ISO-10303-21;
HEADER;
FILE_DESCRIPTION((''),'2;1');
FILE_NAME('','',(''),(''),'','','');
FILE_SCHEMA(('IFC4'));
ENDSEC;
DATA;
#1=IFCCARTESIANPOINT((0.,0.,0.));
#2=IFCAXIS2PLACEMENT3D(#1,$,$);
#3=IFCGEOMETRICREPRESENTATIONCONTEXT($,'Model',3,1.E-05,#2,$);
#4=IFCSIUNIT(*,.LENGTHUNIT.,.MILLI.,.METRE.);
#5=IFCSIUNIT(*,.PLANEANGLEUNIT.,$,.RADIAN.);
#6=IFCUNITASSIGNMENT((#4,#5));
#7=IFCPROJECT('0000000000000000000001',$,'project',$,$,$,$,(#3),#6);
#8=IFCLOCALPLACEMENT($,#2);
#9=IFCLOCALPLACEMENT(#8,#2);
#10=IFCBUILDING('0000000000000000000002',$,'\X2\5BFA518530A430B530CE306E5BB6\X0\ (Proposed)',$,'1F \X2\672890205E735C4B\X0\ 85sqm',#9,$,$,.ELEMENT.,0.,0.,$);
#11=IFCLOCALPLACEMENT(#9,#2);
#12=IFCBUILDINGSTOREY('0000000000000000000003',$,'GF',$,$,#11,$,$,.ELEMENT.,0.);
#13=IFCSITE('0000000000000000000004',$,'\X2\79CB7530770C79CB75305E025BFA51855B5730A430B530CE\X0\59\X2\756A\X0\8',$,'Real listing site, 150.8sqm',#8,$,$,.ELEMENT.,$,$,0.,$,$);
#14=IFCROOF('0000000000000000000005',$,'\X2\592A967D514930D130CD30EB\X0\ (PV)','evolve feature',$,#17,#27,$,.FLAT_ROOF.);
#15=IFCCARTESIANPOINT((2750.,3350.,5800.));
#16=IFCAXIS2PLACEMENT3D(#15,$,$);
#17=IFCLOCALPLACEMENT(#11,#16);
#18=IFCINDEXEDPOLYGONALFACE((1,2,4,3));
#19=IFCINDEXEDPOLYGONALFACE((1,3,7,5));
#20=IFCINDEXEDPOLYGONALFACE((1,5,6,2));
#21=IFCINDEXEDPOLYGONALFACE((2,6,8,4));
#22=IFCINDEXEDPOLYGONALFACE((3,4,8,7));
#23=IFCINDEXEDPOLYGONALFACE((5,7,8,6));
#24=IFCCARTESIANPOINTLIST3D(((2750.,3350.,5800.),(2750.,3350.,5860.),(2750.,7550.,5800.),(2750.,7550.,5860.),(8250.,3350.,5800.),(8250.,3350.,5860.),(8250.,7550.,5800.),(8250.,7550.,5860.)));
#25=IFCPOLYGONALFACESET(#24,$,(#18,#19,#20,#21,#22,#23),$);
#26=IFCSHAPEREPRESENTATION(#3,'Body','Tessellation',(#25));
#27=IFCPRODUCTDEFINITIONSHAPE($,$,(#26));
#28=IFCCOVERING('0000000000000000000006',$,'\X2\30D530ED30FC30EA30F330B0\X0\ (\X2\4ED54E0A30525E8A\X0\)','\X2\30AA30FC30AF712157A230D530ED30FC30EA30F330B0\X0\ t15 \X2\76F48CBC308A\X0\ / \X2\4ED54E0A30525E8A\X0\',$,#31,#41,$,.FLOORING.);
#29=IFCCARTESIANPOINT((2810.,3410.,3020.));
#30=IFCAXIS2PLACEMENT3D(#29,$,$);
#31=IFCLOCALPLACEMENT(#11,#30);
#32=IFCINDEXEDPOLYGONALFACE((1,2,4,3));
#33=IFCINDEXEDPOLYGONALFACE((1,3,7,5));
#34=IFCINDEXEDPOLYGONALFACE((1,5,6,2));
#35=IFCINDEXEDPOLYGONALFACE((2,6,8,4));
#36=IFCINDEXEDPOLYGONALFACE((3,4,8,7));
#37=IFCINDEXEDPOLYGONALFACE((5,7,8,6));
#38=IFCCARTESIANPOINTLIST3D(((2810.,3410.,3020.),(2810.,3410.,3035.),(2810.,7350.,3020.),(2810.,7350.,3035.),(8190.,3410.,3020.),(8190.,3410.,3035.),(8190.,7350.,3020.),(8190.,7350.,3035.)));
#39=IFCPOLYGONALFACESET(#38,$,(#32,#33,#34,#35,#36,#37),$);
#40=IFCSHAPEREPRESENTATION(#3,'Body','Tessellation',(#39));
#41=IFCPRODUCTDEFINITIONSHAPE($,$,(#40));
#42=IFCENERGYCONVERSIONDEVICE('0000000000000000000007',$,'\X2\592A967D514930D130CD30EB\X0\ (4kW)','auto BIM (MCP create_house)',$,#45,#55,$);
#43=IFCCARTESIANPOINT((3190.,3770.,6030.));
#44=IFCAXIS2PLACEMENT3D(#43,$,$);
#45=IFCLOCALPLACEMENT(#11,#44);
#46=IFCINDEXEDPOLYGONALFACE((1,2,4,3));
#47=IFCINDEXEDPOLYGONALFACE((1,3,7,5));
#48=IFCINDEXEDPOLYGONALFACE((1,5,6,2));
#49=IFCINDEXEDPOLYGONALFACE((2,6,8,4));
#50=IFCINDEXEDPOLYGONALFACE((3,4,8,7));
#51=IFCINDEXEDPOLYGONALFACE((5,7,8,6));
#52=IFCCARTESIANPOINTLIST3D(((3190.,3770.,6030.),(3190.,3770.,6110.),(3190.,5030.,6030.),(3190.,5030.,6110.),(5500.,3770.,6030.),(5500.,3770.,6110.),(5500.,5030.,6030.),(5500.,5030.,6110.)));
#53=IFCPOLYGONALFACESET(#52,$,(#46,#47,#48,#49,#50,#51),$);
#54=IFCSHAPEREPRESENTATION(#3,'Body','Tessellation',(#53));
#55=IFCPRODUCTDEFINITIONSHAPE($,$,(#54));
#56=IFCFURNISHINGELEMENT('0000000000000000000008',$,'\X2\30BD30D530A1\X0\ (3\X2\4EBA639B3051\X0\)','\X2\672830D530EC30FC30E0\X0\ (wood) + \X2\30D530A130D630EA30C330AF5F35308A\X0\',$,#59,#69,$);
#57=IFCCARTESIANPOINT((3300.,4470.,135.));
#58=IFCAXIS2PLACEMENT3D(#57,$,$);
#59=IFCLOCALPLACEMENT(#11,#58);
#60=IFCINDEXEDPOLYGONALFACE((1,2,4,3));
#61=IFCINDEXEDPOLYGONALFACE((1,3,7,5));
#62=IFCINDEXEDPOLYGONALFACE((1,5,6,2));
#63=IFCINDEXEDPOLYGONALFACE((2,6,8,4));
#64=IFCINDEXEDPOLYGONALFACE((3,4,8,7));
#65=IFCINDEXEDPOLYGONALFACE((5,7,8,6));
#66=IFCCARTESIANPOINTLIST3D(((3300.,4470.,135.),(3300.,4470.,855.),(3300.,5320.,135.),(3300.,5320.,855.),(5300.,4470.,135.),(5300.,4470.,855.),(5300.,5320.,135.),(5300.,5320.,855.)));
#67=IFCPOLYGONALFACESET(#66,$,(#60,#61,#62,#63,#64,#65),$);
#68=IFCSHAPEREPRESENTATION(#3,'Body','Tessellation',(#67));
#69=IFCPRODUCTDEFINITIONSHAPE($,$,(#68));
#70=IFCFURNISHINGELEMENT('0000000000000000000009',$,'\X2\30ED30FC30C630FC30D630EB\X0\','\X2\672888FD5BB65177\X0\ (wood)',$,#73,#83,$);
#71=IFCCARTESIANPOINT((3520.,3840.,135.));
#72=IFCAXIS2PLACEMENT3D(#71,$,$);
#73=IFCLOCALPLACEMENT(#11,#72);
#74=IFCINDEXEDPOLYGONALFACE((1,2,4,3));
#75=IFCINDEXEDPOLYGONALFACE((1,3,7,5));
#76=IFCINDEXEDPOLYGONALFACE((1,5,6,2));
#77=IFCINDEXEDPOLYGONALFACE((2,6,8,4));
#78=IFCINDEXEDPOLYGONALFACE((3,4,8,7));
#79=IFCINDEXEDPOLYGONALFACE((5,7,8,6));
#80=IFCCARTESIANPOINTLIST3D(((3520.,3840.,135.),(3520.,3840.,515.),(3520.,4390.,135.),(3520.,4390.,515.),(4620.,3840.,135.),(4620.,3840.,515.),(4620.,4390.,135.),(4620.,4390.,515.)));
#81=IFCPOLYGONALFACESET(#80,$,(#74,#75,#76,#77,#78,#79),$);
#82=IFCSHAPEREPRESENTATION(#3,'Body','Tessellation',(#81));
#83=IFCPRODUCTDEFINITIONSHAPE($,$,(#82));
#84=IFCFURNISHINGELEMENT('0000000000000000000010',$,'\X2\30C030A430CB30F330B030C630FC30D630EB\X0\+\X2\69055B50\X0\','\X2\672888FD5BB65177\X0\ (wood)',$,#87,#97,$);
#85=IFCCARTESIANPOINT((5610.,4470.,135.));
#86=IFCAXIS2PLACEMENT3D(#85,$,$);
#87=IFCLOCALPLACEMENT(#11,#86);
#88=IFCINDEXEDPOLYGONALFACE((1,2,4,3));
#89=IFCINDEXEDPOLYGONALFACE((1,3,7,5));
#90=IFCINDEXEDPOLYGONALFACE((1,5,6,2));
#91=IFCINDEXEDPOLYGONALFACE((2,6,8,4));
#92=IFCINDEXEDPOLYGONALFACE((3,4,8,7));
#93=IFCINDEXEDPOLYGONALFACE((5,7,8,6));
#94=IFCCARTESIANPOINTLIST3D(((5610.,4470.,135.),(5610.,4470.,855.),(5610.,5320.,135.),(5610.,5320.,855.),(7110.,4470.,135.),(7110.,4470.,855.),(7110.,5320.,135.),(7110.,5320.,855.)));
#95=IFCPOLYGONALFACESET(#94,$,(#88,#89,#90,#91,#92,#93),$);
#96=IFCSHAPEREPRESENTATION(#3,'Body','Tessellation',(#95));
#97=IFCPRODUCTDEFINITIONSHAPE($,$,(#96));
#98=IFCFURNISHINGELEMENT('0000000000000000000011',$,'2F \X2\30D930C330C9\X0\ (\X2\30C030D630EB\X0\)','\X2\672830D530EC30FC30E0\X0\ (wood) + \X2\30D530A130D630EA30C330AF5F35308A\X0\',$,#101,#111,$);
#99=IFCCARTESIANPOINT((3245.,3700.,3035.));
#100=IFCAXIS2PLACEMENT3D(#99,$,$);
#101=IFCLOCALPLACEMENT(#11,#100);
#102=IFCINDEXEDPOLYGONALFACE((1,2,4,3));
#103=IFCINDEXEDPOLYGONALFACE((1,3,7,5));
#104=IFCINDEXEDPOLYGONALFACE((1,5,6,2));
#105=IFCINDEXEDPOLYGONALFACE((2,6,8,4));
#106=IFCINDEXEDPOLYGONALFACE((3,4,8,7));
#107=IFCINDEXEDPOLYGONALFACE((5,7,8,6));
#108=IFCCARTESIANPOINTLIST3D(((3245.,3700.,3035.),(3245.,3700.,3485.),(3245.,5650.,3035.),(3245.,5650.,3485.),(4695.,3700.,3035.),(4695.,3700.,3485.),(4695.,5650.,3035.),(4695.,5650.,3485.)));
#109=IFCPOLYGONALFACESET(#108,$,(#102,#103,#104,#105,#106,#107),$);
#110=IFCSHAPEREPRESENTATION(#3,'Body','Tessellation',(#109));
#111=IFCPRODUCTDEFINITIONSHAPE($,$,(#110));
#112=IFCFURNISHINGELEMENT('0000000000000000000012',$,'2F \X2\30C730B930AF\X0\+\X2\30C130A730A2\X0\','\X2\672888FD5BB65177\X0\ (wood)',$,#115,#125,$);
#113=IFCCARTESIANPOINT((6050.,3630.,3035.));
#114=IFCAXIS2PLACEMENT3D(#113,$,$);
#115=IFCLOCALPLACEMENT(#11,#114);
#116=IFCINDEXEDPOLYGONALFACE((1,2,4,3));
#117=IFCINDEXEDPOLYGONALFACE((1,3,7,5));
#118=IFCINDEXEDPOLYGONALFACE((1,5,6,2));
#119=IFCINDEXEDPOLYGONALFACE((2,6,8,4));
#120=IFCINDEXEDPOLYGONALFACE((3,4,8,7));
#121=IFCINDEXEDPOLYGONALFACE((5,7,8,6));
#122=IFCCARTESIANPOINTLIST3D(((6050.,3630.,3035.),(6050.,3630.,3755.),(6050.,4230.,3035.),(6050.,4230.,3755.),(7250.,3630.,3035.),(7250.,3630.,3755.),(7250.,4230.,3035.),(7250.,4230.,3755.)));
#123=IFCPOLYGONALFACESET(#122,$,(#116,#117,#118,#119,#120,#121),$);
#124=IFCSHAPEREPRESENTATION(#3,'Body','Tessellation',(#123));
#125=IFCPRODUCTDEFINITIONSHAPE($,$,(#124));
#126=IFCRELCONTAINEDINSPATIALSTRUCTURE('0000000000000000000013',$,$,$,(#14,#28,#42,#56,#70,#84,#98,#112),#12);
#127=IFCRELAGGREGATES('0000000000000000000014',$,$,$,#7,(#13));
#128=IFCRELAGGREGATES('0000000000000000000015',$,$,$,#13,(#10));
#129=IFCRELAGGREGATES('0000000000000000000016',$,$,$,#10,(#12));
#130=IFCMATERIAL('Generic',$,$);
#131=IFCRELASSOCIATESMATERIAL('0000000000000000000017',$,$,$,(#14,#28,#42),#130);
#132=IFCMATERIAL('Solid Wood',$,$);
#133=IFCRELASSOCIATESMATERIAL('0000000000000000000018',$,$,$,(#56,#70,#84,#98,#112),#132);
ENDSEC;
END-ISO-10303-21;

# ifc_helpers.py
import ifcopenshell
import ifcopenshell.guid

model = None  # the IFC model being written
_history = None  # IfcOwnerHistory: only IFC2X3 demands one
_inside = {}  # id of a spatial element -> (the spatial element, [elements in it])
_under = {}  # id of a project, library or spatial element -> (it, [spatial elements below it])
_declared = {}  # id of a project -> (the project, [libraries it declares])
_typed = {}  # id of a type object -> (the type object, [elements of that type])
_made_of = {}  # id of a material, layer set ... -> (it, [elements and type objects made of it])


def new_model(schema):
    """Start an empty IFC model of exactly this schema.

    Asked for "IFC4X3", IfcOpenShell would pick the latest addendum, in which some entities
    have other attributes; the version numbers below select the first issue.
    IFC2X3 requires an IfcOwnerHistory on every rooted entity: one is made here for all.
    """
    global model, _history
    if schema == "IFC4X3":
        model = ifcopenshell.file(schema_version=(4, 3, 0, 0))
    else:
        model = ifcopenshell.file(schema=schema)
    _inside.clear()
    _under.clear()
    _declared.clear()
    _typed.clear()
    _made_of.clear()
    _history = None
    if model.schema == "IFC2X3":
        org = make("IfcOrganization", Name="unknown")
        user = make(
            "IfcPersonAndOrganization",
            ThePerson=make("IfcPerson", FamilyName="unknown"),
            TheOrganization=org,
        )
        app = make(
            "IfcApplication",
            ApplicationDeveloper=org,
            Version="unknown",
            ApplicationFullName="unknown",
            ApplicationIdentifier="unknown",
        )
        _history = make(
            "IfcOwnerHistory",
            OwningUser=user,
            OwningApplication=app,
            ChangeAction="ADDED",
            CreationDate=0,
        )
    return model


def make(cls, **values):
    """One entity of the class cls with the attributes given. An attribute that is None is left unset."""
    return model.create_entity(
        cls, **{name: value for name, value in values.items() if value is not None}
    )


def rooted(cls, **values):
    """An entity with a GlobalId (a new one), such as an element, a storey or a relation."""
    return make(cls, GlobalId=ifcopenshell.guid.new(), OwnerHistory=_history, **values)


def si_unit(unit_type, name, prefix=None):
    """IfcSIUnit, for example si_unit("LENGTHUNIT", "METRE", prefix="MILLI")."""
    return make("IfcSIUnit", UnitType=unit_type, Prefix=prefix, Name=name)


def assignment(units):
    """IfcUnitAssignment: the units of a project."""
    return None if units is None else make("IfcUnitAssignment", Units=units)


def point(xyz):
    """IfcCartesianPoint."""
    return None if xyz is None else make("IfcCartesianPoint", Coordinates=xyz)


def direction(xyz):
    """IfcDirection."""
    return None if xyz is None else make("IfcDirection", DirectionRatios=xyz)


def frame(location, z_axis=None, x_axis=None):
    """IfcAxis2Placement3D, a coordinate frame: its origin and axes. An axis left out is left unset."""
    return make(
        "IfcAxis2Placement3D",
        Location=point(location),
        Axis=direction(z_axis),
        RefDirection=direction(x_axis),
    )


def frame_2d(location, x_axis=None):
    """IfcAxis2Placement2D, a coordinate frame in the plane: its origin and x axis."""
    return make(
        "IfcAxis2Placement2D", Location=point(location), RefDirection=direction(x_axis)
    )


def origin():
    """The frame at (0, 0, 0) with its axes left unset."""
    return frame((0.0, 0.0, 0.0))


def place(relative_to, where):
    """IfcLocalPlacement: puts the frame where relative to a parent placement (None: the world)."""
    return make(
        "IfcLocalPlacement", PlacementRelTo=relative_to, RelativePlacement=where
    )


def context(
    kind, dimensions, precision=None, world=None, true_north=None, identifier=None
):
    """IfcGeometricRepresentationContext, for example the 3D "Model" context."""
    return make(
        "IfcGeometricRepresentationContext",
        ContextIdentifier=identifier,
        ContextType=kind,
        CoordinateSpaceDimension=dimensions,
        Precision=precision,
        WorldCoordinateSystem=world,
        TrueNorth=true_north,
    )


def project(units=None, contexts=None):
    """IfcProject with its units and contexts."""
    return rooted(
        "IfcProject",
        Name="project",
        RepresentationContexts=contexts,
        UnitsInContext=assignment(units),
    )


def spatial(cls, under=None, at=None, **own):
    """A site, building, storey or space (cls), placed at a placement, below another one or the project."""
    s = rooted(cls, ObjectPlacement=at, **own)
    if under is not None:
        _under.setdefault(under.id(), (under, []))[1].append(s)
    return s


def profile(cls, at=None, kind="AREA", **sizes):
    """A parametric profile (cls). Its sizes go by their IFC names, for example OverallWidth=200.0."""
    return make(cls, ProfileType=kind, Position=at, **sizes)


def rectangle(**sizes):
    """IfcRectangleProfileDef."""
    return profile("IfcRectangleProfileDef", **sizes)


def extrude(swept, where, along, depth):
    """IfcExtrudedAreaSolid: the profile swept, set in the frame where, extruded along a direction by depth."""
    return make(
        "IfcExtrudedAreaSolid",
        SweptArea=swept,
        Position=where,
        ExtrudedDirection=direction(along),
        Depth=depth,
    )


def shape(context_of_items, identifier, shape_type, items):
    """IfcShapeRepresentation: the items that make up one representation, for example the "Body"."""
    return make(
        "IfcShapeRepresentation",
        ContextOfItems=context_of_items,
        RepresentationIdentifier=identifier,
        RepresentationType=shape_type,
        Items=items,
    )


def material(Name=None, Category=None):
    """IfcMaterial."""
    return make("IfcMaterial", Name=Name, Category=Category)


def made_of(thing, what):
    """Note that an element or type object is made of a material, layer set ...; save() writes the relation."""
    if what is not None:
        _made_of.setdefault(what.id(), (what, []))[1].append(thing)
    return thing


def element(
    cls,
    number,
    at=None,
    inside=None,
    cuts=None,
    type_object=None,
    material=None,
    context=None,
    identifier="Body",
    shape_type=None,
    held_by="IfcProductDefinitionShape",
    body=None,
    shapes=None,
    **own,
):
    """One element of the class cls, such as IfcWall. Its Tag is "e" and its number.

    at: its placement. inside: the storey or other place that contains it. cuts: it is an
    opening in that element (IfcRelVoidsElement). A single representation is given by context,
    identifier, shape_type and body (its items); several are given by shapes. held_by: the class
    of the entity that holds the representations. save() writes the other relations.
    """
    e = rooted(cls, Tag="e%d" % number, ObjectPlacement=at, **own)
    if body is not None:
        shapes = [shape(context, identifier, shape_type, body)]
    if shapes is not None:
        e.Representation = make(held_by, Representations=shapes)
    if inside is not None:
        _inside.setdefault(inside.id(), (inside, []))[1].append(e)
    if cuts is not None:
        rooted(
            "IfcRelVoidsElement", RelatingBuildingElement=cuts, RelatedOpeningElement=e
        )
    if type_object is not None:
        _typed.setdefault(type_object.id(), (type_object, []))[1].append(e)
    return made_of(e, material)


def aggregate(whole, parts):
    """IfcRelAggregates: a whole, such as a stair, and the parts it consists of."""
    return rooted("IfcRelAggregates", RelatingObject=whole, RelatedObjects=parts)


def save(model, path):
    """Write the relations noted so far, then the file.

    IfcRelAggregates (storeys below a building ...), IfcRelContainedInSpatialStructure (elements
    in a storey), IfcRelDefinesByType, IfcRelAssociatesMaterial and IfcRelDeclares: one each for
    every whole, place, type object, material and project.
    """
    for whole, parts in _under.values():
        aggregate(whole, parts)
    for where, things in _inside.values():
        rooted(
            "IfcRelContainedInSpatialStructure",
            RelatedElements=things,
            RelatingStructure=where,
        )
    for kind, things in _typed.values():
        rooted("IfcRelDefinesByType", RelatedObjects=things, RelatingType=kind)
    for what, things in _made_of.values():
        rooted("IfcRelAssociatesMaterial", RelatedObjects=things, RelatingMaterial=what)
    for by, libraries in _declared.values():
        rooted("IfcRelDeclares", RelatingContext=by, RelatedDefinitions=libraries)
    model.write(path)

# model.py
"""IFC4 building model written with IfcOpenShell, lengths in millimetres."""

from ifc_helpers import new_model, si_unit, frame, frame_2d, origin, place, context, project, spatial, rectangle, extrude, material, element, save


model = new_model("IFC4")

# Units and contexts
model_context = context("Model", 3, precision=1e-05, world=origin())
ifc_project = project(units=[si_unit("LENGTHUNIT", "METRE", prefix="MILLI"), si_unit("PLANEANGLEUNIT", "RADIAN")], contexts=[model_context])

# Site, building, storey
site_placement = place(None, origin())
site = spatial("IfcSite", under=ifc_project, at=site_placement, Name="秋田県秋田市寺内字イサノ59番8", ObjectType="Real listing site, 150.8sqm", CompositionType="ELEMENT", RefElevation=0.0)
building_placement = place(site_placement, origin())
building = spatial("IfcBuilding", under=site, at=building_placement, Name="寺内イサノの家 (Proposed)", ObjectType="1F 木造平屋 85sqm", CompositionType="ELEMENT", ElevationOfRefHeight=0.0, ElevationOfTerrain=0.0)
storey_placement = place(building_placement, origin())
storey = spatial("IfcBuildingStorey", under=building, at=storey_placement, Name="GF", CompositionType="ELEMENT", Elevation=0.0)

# Shared definitions
ifc_material_1 = material(Name="Solid Wood")

# Shared definitions
ifc_material_2 = material(Name="Generic")

# Roof
roof_placement = place(storey_placement, frame((2750.0, 3350.0, 5800.0)))
element("IfcRoof", 1, at=roof_placement, inside=storey, material=ifc_material_2, Name="太陽光パネル (PV)", Description="evolve feature", PredefinedType="FLAT_ROOF", context=model_context, shape_type="SweptSolid", body=[
    extrude(rectangle(XDim=5500.0, YDim=4200.0, at=frame_2d((2750.0, 2100.0))), frame((2750.0, 3350.0, 5800.0)), (0.0, 0.0, 1.0), 60.0),
])

# Covering
covering_placement = place(storey_placement, frame((2810.0, 3410.0, 3020.0)))
element("IfcCovering", 2, at=covering_placement, inside=storey, material=ifc_material_2, Name="フローリング (仕上げ床)", Description="オーク無垢フローリング t15 直貼り / 仕上げ床", PredefinedType="FLOORING", context=model_context, shape_type="SweptSolid", body=[
    extrude(rectangle(XDim=5380.0, YDim=3940.0, at=frame_2d((2690.0, 1970.0))), frame((2810.0, 3410.0, 3020.0)), (0.0, 0.0, 1.0), 15.0),
])

# Energy conversion device
energy_conversion_device_placement = place(storey_placement, frame((3190.0, 3770.0, 6030.0)))
element("IfcEnergyConversionDevice", 3, at=energy_conversion_device_placement, inside=storey, material=ifc_material_2, Name="太陽光パネル (4kW)", Description="auto BIM (MCP create_house)", context=model_context, shape_type="SweptSolid", body=[
    extrude(rectangle(XDim=2310.0, YDim=1260.0, at=frame_2d((1155.0, 630.0))), frame((3190.0, 3770.0, 6030.0)), (0.0, 0.0, 1.0), 80.0),
])

# Furnishing elements
furnishing_1_placement = place(storey_placement, frame((3300.0, 4470.0, 135.0)))
element("IfcFurnishingElement", 4, at=furnishing_1_placement, inside=storey, material=ifc_material_1, Name="ソファ (3人掛け)", Description="木フレーム (wood) + ファブリック張り", context=model_context, shape_type="SweptSolid", body=[
    extrude(rectangle(XDim=2000.0, YDim=850.0, at=frame_2d((1000.0, 425.0))), frame((3300.0, 4470.0, 135.0)), (0.0, 0.0, 1.0), 720.0),
])
furnishing_2_placement = place(storey_placement, frame((3520.0, 3840.0, 135.0)))
element("IfcFurnishingElement", 5, at=furnishing_2_placement, inside=storey, material=ifc_material_1, Name="ローテーブル", Description="木製家具 (wood)", context=model_context, shape_type="SweptSolid", body=[
    extrude(rectangle(XDim=1100.0, YDim=550.0, at=frame_2d((550.0, 275.0))), frame((3520.0, 3840.0, 135.0)), (0.0, 0.0, 1.0), 380.0),
])
furnishing_3_placement = place(storey_placement, frame((5610.0, 4470.0, 135.0)))
element("IfcFurnishingElement", 6, at=furnishing_3_placement, inside=storey, material=ifc_material_1, Name="ダイニングテーブル+椅子", Description="木製家具 (wood)", context=model_context, shape_type="SweptSolid", body=[
    extrude(rectangle(XDim=1500.0, YDim=850.0, at=frame_2d((750.0, 425.0))), frame((5610.0, 4470.0, 135.0)), (0.0, 0.0, 1.0), 720.0),
])
furnishing_4_placement = place(storey_placement, frame((3245.0, 3700.0, 3035.0)))
element("IfcFurnishingElement", 7, at=furnishing_4_placement, inside=storey, material=ifc_material_1, Name="2F ベッド (ダブル)", Description="木フレーム (wood) + ファブリック張り", context=model_context, shape_type="SweptSolid", body=[
    extrude(rectangle(XDim=1450.0, YDim=1950.0, at=frame_2d((725.0, 975.0))), frame((3245.0, 3700.0, 3035.0)), (0.0, 0.0, 1.0), 450.0),
])
furnishing_5_placement = place(storey_placement, frame((6050.0, 3630.0, 3035.0)))
element("IfcFurnishingElement", 8, at=furnishing_5_placement, inside=storey, material=ifc_material_1, Name="2F デスク+チェア", Description="木製家具 (wood)", context=model_context, shape_type="SweptSolid", body=[
    extrude(rectangle(XDim=1200.0, YDim=600.0, at=frame_2d((600.0, 300.0))), frame((6050.0, 3630.0, 3035.0)), (0.0, 0.0, 1.0), 720.0),
])

save(model, "model.ifc")
